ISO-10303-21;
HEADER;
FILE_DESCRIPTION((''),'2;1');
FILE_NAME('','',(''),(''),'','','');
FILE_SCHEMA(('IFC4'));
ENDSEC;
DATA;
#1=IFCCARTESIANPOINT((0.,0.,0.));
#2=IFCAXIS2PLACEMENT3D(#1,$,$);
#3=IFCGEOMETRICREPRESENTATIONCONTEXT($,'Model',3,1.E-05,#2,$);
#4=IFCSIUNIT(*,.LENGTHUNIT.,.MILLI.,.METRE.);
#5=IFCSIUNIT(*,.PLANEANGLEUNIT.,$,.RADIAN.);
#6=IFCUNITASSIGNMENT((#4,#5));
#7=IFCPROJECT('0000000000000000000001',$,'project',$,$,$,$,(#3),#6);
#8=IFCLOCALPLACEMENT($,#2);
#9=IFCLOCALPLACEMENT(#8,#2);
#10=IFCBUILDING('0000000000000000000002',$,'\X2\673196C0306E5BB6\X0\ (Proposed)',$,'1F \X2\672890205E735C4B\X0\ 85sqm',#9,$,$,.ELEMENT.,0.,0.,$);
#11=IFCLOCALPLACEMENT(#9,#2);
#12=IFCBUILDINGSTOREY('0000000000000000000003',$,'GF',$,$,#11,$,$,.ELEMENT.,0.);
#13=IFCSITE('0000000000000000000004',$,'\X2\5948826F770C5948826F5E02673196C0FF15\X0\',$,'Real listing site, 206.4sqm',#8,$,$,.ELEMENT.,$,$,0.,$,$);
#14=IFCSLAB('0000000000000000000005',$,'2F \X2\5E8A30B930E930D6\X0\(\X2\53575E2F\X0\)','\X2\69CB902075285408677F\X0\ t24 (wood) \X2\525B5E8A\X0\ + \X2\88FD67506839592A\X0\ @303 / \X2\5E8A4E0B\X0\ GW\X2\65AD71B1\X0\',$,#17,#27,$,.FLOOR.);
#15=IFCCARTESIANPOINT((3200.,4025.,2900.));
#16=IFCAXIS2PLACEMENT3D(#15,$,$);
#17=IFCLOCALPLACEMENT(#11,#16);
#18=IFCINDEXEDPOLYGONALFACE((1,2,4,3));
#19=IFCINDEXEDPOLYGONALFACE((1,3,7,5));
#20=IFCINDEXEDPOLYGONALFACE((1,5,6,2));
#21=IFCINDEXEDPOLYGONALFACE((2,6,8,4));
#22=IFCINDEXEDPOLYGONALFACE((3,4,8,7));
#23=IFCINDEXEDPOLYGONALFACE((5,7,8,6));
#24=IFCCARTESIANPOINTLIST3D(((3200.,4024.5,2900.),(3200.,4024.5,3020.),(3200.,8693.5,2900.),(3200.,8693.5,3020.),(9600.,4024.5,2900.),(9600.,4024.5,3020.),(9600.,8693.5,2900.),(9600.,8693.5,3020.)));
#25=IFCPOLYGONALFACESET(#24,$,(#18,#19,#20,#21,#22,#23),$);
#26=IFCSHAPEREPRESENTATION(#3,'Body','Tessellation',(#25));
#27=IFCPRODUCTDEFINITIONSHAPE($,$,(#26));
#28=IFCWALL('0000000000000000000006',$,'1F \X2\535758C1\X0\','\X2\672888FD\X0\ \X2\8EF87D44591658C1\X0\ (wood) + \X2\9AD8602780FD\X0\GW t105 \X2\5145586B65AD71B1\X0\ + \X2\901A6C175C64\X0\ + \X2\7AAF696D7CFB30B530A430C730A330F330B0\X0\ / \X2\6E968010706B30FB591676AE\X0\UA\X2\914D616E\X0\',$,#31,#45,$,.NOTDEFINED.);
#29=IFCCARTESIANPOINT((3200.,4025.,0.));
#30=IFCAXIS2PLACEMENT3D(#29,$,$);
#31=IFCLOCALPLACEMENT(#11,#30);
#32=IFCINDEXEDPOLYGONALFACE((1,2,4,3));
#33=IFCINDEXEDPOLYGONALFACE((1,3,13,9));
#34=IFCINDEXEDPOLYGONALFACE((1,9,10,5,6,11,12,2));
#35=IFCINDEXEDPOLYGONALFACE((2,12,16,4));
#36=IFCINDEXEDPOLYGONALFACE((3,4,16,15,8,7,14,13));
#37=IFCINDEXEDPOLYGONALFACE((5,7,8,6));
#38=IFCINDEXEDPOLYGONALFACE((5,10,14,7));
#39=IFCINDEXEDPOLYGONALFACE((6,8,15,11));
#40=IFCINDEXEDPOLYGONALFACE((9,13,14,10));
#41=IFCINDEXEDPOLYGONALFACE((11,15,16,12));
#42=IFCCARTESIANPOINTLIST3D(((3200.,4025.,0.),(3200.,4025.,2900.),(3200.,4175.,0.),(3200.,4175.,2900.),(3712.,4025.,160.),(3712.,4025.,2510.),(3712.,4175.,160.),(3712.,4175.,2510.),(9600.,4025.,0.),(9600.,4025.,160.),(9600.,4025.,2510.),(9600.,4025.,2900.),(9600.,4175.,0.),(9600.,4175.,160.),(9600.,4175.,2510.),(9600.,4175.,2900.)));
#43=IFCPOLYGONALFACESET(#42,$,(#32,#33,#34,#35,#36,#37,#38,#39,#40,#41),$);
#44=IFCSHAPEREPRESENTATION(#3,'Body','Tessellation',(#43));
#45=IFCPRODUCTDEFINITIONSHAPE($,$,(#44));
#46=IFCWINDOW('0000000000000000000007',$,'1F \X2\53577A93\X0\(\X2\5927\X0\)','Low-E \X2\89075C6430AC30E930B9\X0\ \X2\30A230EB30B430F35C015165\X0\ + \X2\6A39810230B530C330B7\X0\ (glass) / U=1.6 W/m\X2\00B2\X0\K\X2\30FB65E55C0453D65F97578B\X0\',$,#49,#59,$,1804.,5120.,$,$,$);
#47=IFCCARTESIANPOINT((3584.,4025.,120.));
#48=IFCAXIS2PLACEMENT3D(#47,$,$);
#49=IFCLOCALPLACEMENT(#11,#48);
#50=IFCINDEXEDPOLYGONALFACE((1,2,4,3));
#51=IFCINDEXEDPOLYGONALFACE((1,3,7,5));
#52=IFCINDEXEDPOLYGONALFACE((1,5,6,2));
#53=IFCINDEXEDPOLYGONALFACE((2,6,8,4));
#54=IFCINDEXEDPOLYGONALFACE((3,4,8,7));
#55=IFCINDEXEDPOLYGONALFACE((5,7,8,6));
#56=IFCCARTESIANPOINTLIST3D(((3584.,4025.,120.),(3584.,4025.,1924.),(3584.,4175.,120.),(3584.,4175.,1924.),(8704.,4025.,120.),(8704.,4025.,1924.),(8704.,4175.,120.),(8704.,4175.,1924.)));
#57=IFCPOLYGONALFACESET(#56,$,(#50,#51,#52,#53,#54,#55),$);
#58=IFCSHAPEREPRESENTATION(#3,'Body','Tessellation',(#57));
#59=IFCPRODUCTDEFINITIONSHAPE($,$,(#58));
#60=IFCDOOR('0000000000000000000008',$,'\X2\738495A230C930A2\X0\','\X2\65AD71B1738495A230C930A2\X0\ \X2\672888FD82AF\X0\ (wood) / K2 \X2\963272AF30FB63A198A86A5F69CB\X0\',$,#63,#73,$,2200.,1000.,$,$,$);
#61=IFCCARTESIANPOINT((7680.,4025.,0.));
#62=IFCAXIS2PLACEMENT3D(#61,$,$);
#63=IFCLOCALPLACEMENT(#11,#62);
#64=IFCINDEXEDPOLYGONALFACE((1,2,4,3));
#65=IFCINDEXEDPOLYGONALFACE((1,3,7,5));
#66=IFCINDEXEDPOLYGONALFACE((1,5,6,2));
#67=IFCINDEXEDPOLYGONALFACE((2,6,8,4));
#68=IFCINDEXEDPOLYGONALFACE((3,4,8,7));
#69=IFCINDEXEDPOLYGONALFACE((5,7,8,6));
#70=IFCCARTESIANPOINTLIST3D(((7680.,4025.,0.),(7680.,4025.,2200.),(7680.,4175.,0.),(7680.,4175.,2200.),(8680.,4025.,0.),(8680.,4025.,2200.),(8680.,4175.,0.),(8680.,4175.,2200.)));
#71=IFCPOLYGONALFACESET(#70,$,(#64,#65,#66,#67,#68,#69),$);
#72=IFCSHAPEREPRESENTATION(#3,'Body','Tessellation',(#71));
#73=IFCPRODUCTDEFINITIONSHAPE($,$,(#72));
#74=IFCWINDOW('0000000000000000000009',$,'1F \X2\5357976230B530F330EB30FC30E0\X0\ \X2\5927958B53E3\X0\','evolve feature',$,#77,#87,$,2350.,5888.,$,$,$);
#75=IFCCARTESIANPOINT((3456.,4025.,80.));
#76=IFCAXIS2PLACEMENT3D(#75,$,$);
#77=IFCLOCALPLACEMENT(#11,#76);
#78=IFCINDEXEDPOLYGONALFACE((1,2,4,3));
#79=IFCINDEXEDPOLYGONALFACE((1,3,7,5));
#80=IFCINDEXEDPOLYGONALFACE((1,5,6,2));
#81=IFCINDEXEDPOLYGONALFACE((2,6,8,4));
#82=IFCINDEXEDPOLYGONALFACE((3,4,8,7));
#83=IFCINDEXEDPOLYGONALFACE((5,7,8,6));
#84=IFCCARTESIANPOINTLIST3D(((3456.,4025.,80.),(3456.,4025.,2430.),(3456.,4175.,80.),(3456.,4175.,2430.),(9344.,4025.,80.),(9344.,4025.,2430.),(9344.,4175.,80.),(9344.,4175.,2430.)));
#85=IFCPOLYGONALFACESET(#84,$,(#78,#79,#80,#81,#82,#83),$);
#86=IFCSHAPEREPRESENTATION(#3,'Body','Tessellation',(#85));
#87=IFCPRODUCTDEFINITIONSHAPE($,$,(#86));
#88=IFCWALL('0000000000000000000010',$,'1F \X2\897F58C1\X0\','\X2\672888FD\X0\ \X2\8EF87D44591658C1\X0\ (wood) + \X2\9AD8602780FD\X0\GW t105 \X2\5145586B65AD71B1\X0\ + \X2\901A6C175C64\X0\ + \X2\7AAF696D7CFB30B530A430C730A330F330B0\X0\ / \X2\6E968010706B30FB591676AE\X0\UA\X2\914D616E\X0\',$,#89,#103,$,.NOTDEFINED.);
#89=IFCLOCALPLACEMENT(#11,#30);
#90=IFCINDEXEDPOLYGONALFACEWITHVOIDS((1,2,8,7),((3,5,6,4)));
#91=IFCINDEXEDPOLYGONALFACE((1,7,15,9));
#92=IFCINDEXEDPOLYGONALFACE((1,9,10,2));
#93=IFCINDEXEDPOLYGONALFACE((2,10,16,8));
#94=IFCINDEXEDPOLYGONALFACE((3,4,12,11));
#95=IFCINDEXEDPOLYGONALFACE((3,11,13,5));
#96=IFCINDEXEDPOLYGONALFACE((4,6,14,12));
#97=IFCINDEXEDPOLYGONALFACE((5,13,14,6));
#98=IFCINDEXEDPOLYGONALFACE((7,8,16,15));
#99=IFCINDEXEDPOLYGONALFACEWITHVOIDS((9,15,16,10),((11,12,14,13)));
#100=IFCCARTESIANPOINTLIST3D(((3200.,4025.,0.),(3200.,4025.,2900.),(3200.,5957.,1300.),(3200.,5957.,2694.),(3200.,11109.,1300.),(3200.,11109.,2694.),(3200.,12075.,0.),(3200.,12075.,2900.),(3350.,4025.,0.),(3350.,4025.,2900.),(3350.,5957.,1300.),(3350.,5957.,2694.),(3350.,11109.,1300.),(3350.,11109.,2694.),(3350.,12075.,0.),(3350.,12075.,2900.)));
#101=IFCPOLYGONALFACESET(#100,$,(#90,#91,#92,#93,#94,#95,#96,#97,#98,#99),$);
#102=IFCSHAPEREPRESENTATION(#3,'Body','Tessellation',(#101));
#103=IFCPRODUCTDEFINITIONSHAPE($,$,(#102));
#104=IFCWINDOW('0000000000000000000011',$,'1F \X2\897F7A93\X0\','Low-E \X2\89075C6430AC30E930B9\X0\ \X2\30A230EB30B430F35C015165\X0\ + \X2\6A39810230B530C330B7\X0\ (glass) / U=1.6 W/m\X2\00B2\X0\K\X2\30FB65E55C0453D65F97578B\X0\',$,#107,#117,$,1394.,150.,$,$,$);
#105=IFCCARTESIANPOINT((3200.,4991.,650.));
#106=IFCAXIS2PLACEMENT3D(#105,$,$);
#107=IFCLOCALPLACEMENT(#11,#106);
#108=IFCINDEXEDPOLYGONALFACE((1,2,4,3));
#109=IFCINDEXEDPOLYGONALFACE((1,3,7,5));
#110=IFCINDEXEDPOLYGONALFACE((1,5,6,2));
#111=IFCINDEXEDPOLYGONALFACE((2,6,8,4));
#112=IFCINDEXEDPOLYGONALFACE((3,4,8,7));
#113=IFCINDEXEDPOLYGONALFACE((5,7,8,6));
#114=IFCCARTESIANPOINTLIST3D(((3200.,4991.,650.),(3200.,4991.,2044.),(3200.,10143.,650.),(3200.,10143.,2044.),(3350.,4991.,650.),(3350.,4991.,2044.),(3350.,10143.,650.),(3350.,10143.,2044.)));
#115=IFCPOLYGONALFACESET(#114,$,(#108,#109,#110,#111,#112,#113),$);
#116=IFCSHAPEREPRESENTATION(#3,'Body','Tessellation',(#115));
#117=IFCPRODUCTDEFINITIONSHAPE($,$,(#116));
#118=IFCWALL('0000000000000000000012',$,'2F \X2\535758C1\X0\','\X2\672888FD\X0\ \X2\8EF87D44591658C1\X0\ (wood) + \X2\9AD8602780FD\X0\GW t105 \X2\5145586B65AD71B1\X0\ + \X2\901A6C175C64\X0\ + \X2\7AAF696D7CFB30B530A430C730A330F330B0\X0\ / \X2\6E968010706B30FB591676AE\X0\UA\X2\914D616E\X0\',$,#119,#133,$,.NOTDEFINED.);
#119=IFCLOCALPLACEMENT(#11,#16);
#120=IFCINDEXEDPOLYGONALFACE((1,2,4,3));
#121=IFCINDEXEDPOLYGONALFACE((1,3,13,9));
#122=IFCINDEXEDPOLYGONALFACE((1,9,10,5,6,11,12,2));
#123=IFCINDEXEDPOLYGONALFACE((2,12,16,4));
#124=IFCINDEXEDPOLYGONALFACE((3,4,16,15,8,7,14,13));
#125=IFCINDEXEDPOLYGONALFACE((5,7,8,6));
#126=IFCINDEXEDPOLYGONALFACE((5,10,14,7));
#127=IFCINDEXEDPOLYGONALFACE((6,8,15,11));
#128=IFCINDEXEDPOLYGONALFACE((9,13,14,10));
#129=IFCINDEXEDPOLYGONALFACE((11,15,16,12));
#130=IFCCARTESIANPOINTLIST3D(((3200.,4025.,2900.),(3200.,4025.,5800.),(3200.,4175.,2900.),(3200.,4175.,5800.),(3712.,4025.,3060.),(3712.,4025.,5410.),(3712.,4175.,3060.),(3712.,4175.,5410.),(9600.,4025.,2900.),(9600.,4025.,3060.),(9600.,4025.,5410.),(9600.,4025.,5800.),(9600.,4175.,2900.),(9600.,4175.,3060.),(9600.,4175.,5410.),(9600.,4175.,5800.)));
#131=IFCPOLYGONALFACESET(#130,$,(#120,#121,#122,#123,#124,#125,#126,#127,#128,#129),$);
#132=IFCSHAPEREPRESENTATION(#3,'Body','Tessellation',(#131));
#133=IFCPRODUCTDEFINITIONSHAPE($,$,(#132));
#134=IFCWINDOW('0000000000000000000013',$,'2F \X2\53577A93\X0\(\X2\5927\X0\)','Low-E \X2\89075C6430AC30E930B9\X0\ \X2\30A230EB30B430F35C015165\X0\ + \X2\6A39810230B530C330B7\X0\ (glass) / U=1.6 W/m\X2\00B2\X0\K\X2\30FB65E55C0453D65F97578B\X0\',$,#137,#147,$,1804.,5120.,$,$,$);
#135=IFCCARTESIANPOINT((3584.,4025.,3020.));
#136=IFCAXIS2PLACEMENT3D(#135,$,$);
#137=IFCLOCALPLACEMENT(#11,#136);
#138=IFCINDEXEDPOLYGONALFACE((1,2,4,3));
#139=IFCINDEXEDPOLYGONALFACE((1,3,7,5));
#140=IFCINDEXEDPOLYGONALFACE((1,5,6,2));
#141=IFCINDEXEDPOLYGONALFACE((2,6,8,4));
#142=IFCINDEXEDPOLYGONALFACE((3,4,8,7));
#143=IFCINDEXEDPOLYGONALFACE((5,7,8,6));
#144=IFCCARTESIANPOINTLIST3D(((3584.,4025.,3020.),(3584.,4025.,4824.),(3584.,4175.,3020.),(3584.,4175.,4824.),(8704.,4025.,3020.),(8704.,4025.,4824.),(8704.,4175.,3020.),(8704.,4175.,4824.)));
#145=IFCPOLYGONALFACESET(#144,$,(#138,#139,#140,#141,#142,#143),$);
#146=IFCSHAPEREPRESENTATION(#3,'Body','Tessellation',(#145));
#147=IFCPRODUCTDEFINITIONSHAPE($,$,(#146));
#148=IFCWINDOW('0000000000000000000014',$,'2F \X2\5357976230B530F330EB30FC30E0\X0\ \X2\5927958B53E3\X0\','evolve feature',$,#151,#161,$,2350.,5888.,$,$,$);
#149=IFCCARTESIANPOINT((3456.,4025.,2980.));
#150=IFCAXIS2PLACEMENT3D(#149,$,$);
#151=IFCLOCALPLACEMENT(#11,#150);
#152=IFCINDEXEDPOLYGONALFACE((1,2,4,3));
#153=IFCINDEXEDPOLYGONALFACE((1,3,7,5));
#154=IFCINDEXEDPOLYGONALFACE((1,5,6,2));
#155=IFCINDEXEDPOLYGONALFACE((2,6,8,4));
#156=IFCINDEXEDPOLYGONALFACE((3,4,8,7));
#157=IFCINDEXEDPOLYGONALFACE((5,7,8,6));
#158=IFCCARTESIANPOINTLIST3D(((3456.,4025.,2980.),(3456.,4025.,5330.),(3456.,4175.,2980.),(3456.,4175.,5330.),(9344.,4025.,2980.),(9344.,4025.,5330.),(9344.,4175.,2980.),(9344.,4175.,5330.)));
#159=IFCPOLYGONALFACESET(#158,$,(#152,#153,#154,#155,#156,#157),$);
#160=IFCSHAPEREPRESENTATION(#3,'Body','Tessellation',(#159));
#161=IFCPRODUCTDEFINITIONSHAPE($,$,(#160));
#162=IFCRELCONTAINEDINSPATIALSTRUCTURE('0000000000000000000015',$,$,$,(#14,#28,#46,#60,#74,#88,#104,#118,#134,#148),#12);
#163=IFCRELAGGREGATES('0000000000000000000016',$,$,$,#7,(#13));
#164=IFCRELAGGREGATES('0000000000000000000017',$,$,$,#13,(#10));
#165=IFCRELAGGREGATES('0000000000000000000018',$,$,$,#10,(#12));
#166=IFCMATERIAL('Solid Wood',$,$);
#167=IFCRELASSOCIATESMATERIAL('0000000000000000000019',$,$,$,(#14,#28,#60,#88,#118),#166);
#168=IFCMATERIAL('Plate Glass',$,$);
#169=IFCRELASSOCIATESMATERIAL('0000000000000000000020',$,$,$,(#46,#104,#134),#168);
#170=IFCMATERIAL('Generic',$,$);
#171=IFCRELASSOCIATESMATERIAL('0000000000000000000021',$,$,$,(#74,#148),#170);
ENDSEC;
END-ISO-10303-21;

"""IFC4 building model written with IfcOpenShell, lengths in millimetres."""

from ifc_helpers import new_model, si_unit, frame, frame_2d, origin, place, context, project, spatial, rectangle, extrude, material, element, fill, save


model = new_model("IFC4")

# Units and contexts
model_context = context("Model", 3, precision=1e-05, world=origin())
ifc_project = project(units=[si_unit("LENGTHUNIT", "METRE", prefix="MILLI"), si_unit("PLANEANGLEUNIT", "RADIAN")], contexts=[model_context])

# Site, building, storey
site_placement = place(None, origin())
site = spatial("IfcSite", under=ifc_project, at=site_placement, Name="奈良県奈良市朱雀５", ObjectType="Real listing site, 206.4sqm", CompositionType="ELEMENT", RefElevation=0.0)
building_placement = place(site_placement, origin())
building = spatial("IfcBuilding", under=site, at=building_placement, Name="朱雀の家 (Proposed)", ObjectType="1F 木造平屋 85sqm", CompositionType="ELEMENT", ElevationOfRefHeight=0.0, ElevationOfTerrain=0.0)
storey_placement = place(building_placement, origin())
storey = spatial("IfcBuildingStorey", under=building, at=storey_placement, Name="GF", CompositionType="ELEMENT", Elevation=0.0)

# Slab
ifc_material_1 = material(Name="Solid Wood")
slab_1_placement = place(storey_placement, frame((3200.0, 4025.0, 2900.0)))
element("IfcSlab", 1, at=slab_1_placement, inside=storey, material=ifc_material_1, Name="2F 床スラブ(南帯)", Description="構造用合板 t24 (wood) 剛床 + 製材根太 @303 / 床下 GW断熱", PredefinedType="FLOOR", context=model_context, shape_type="SweptSolid", body=[
    extrude(rectangle(XDim=6400.0, YDim=4669.0, at=frame_2d((3200.0, 2334.0))), frame((3200.0, 4025.0, 2900.0)), (0.0, 0.0, 1.0), 120.0),
])
ifc_material_2 = material(Name="Generic")

# Wall, openings, windows, door
wall_1_placement = place(storey_placement, frame((3200.0, 4025.0, 0.0)))
wall_1 = element("IfcWall", 2, at=wall_1_placement, inside=storey, material=ifc_material_1, Name="1F 南壁", Description="木製 軸組外壁 (wood) + 高性能GW t105 充填断熱 + 通気層 + 窯業系サイディング / 準耐火・外皮UA配慮", PredefinedType="NOTDEFINED", context=model_context, shape_type="SweptSolid", body=[
    extrude(rectangle(XDim=6400.0, YDim=150.0, at=frame_2d((3200.0, 75.0))), frame((3200.0, 4025.0, 0.0)), (0.0, 0.0, 1.0), 2900.0),
])
opening_1_placement = place(storey_placement, frame((3584.0, 4025.0, 120.0)))
opening_1 = element("IfcOpeningElement", 3, at=opening_1_placement, cuts=wall_1, PredefinedType="NOTDEFINED", context=model_context, shape_type="SweptSolid", body=[
    extrude(rectangle(XDim=5120.0, YDim=150.0, at=frame_2d((2560.0, 75.0))), frame((3584.0, 4025.0, 120.0)), (0.0, 0.0, 1.0), 1804.0),
])
opening_2_placement = place(storey_placement, frame((7680.0, 4025.0, 0.0)))
opening_2 = element("IfcOpeningElement", 4, at=opening_2_placement, cuts=wall_1, PredefinedType="NOTDEFINED", context=model_context, shape_type="SweptSolid", body=[
    extrude(rectangle(XDim=1000.0, YDim=150.0, at=frame_2d((500.0, 75.0))), frame((7680.0, 4025.0, 0.0)), (0.0, 0.0, 1.0), 2200.0),
])
opening_3_placement = place(storey_placement, frame((3456.0, 4025.0, 80.0)))
opening_3 = element("IfcOpeningElement", 5, at=opening_3_placement, cuts=wall_1, PredefinedType="NOTDEFINED", context=model_context, shape_type="SweptSolid", body=[
    extrude(rectangle(XDim=5888.0, YDim=150.0, at=frame_2d((2944.0, 75.0))), frame((3456.0, 4025.0, 80.0)), (0.0, 0.0, 1.0), 2350.0),
])
ifc_material_3 = material(Name="Plate Glass")
window_1_placement = place(storey_placement, frame((3584.0, 4025.0, 120.0)))
window_1 = element("IfcWindow", 6, at=window_1_placement, inside=storey, material=ifc_material_3, Name="1F 南窓(大)", Description="Low-E 複層ガラス アルゴン封入 + 樹脂サッシ (glass) / U=1.6 W/m²K・日射取得型", OverallHeight=1804.0, OverallWidth=5120.0, context=model_context, shape_type="SweptSolid", body=[
    extrude(rectangle(XDim=5120.0, YDim=150.0, at=frame_2d((2560.0, 75.0))), frame((3584.0, 4025.0, 120.0)), (0.0, 0.0, 1.0), 1804.0),
])
fill(opening_1, window_1)
door_placement = place(storey_placement, frame((7680.0, 4025.0, 0.0)))
door = element("IfcDoor", 7, at=door_placement, inside=storey, material=ifc_material_1, Name="玄関ドア", Description="断熱玄関ドア 木製芯 (wood) / K2 防犯・採風機構", OverallHeight=2200.0, OverallWidth=1000.0, context=model_context, shape_type="SweptSolid", body=[
    extrude(rectangle(XDim=1000.0, YDim=150.0, at=frame_2d((500.0, 75.0))), frame((7680.0, 4025.0, 0.0)), (0.0, 0.0, 1.0), 2200.0),
])
fill(opening_2, door)
window_2_placement = place(storey_placement, frame((3456.0, 4025.0, 80.0)))
window_2 = element("IfcWindow", 8, at=window_2_placement, inside=storey, material=ifc_material_2, Name="1F 南面サンルーム 大開口", Description="evolve feature", OverallHeight=2350.0, OverallWidth=5888.0, context=model_context, shape_type="SweptSolid", body=[
    extrude(rectangle(XDim=5888.0, YDim=150.0, at=frame_2d((2944.0, 75.0))), frame((3456.0, 4025.0, 80.0)), (0.0, 0.0, 1.0), 2350.0),
])
fill(opening_3, window_2)

# Wall, opening, window
wall_2_placement = place(storey_placement, frame((3200.0, 4025.0, 0.0)))
wall_2 = element("IfcWall", 9, at=wall_2_placement, inside=storey, material=ifc_material_1, Name="1F 西壁", Description="木製 軸組外壁 (wood) + 高性能GW t105 充填断熱 + 通気層 + 窯業系サイディング / 準耐火・外皮UA配慮", PredefinedType="NOTDEFINED", context=model_context, shape_type="SweptSolid", body=[
    extrude(rectangle(XDim=150.0, YDim=8050.0, at=frame_2d((75.0, 4025.0))), frame((3200.0, 4025.0, 0.0)), (0.0, 0.0, 1.0), 2900.0),
])
opening_4_placement = place(storey_placement, frame((3200.0, 4991.0, 650.0)))
opening_4 = element("IfcOpeningElement", 10, at=opening_4_placement, cuts=wall_2, PredefinedType="NOTDEFINED", context=model_context, shape_type="SweptSolid", body=[
    extrude(rectangle(XDim=150.0, YDim=5152.0, at=frame_2d((75.0, 2576.0))), frame((3200.0, 4991.0, 650.0)), (0.0, 0.0, 1.0), 1394.0),
])
window_3_placement = place(storey_placement, frame((3200.0, 4991.0, 650.0)))
window_3 = element("IfcWindow", 11, at=window_3_placement, inside=storey, material=ifc_material_3, Name="1F 西窓", Description="Low-E 複層ガラス アルゴン封入 + 樹脂サッシ (glass) / U=1.6 W/m²K・日射取得型", OverallHeight=1394.0, OverallWidth=150.0, context=model_context, shape_type="SweptSolid", body=[
    extrude(rectangle(XDim=150.0, YDim=5152.0, at=frame_2d((75.0, 2576.0))), frame((3200.0, 4991.0, 650.0)), (0.0, 0.0, 1.0), 1394.0),
])
fill(opening_4, window_3)

# Wall, openings, windows
wall_3_placement = place(storey_placement, frame((3200.0, 4025.0, 2900.0)))
wall_3 = element("IfcWall", 12, at=wall_3_placement, inside=storey, material=ifc_material_1, Name="2F 南壁", Description="木製 軸組外壁 (wood) + 高性能GW t105 充填断熱 + 通気層 + 窯業系サイディング / 準耐火・外皮UA配慮", PredefinedType="NOTDEFINED", context=model_context, shape_type="SweptSolid", body=[
    extrude(rectangle(XDim=6400.0, YDim=150.0, at=frame_2d((3200.0, 75.0))), frame((3200.0, 4025.0, 2900.0)), (0.0, 0.0, 1.0), 2900.0),
])
opening_5_placement = place(storey_placement, frame((3584.0, 4025.0, 3020.0)))
opening_5 = element("IfcOpeningElement", 13, at=opening_5_placement, cuts=wall_3, PredefinedType="NOTDEFINED", context=model_context, shape_type="SweptSolid", body=[
    extrude(rectangle(XDim=5120.0, YDim=150.0, at=frame_2d((2560.0, 75.0))), frame((3584.0, 4025.0, 3020.0)), (0.0, 0.0, 1.0), 1804.0),
])
opening_6_placement = place(storey_placement, frame((3456.0, 4025.0, 2980.0)))
opening_6 = element("IfcOpeningElement", 14, at=opening_6_placement, cuts=wall_3, PredefinedType="NOTDEFINED", context=model_context, shape_type="SweptSolid", body=[
    extrude(rectangle(XDim=5888.0, YDim=150.0, at=frame_2d((2944.0, 75.0))), frame((3456.0, 4025.0, 2980.0)), (0.0, 0.0, 1.0), 2350.0),
])
window_4_placement = place(storey_placement, frame((3584.0, 4025.0, 3020.0)))
window_4 = element("IfcWindow", 15, at=window_4_placement, inside=storey, material=ifc_material_3, Name="2F 南窓(大)", Description="Low-E 複層ガラス アルゴン封入 + 樹脂サッシ (glass) / U=1.6 W/m²K・日射取得型", OverallHeight=1804.0, OverallWidth=5120.0, context=model_context, shape_type="SweptSolid", body=[
    extrude(rectangle(XDim=5120.0, YDim=150.0, at=frame_2d((2560.0, 75.0))), frame((3584.0, 4025.0, 3020.0)), (0.0, 0.0, 1.0), 1804.0),
])
fill(opening_5, window_4)
window_5_placement = place(storey_placement, frame((3456.0, 4025.0, 2980.0)))
window_5 = element("IfcWindow", 16, at=window_5_placement, inside=storey, material=ifc_material_2, Name="2F 南面サンルーム 大開口", Description="evolve feature", OverallHeight=2350.0, OverallWidth=5888.0, context=model_context, shape_type="SweptSolid", body=[
    extrude(rectangle(XDim=5888.0, YDim=150.0, at=frame_2d((2944.0, 75.0))), frame((3456.0, 4025.0, 2980.0)), (0.0, 0.0, 1.0), 2350.0),
])
fill(opening_6, window_5)

save(model, "model.ifc")
